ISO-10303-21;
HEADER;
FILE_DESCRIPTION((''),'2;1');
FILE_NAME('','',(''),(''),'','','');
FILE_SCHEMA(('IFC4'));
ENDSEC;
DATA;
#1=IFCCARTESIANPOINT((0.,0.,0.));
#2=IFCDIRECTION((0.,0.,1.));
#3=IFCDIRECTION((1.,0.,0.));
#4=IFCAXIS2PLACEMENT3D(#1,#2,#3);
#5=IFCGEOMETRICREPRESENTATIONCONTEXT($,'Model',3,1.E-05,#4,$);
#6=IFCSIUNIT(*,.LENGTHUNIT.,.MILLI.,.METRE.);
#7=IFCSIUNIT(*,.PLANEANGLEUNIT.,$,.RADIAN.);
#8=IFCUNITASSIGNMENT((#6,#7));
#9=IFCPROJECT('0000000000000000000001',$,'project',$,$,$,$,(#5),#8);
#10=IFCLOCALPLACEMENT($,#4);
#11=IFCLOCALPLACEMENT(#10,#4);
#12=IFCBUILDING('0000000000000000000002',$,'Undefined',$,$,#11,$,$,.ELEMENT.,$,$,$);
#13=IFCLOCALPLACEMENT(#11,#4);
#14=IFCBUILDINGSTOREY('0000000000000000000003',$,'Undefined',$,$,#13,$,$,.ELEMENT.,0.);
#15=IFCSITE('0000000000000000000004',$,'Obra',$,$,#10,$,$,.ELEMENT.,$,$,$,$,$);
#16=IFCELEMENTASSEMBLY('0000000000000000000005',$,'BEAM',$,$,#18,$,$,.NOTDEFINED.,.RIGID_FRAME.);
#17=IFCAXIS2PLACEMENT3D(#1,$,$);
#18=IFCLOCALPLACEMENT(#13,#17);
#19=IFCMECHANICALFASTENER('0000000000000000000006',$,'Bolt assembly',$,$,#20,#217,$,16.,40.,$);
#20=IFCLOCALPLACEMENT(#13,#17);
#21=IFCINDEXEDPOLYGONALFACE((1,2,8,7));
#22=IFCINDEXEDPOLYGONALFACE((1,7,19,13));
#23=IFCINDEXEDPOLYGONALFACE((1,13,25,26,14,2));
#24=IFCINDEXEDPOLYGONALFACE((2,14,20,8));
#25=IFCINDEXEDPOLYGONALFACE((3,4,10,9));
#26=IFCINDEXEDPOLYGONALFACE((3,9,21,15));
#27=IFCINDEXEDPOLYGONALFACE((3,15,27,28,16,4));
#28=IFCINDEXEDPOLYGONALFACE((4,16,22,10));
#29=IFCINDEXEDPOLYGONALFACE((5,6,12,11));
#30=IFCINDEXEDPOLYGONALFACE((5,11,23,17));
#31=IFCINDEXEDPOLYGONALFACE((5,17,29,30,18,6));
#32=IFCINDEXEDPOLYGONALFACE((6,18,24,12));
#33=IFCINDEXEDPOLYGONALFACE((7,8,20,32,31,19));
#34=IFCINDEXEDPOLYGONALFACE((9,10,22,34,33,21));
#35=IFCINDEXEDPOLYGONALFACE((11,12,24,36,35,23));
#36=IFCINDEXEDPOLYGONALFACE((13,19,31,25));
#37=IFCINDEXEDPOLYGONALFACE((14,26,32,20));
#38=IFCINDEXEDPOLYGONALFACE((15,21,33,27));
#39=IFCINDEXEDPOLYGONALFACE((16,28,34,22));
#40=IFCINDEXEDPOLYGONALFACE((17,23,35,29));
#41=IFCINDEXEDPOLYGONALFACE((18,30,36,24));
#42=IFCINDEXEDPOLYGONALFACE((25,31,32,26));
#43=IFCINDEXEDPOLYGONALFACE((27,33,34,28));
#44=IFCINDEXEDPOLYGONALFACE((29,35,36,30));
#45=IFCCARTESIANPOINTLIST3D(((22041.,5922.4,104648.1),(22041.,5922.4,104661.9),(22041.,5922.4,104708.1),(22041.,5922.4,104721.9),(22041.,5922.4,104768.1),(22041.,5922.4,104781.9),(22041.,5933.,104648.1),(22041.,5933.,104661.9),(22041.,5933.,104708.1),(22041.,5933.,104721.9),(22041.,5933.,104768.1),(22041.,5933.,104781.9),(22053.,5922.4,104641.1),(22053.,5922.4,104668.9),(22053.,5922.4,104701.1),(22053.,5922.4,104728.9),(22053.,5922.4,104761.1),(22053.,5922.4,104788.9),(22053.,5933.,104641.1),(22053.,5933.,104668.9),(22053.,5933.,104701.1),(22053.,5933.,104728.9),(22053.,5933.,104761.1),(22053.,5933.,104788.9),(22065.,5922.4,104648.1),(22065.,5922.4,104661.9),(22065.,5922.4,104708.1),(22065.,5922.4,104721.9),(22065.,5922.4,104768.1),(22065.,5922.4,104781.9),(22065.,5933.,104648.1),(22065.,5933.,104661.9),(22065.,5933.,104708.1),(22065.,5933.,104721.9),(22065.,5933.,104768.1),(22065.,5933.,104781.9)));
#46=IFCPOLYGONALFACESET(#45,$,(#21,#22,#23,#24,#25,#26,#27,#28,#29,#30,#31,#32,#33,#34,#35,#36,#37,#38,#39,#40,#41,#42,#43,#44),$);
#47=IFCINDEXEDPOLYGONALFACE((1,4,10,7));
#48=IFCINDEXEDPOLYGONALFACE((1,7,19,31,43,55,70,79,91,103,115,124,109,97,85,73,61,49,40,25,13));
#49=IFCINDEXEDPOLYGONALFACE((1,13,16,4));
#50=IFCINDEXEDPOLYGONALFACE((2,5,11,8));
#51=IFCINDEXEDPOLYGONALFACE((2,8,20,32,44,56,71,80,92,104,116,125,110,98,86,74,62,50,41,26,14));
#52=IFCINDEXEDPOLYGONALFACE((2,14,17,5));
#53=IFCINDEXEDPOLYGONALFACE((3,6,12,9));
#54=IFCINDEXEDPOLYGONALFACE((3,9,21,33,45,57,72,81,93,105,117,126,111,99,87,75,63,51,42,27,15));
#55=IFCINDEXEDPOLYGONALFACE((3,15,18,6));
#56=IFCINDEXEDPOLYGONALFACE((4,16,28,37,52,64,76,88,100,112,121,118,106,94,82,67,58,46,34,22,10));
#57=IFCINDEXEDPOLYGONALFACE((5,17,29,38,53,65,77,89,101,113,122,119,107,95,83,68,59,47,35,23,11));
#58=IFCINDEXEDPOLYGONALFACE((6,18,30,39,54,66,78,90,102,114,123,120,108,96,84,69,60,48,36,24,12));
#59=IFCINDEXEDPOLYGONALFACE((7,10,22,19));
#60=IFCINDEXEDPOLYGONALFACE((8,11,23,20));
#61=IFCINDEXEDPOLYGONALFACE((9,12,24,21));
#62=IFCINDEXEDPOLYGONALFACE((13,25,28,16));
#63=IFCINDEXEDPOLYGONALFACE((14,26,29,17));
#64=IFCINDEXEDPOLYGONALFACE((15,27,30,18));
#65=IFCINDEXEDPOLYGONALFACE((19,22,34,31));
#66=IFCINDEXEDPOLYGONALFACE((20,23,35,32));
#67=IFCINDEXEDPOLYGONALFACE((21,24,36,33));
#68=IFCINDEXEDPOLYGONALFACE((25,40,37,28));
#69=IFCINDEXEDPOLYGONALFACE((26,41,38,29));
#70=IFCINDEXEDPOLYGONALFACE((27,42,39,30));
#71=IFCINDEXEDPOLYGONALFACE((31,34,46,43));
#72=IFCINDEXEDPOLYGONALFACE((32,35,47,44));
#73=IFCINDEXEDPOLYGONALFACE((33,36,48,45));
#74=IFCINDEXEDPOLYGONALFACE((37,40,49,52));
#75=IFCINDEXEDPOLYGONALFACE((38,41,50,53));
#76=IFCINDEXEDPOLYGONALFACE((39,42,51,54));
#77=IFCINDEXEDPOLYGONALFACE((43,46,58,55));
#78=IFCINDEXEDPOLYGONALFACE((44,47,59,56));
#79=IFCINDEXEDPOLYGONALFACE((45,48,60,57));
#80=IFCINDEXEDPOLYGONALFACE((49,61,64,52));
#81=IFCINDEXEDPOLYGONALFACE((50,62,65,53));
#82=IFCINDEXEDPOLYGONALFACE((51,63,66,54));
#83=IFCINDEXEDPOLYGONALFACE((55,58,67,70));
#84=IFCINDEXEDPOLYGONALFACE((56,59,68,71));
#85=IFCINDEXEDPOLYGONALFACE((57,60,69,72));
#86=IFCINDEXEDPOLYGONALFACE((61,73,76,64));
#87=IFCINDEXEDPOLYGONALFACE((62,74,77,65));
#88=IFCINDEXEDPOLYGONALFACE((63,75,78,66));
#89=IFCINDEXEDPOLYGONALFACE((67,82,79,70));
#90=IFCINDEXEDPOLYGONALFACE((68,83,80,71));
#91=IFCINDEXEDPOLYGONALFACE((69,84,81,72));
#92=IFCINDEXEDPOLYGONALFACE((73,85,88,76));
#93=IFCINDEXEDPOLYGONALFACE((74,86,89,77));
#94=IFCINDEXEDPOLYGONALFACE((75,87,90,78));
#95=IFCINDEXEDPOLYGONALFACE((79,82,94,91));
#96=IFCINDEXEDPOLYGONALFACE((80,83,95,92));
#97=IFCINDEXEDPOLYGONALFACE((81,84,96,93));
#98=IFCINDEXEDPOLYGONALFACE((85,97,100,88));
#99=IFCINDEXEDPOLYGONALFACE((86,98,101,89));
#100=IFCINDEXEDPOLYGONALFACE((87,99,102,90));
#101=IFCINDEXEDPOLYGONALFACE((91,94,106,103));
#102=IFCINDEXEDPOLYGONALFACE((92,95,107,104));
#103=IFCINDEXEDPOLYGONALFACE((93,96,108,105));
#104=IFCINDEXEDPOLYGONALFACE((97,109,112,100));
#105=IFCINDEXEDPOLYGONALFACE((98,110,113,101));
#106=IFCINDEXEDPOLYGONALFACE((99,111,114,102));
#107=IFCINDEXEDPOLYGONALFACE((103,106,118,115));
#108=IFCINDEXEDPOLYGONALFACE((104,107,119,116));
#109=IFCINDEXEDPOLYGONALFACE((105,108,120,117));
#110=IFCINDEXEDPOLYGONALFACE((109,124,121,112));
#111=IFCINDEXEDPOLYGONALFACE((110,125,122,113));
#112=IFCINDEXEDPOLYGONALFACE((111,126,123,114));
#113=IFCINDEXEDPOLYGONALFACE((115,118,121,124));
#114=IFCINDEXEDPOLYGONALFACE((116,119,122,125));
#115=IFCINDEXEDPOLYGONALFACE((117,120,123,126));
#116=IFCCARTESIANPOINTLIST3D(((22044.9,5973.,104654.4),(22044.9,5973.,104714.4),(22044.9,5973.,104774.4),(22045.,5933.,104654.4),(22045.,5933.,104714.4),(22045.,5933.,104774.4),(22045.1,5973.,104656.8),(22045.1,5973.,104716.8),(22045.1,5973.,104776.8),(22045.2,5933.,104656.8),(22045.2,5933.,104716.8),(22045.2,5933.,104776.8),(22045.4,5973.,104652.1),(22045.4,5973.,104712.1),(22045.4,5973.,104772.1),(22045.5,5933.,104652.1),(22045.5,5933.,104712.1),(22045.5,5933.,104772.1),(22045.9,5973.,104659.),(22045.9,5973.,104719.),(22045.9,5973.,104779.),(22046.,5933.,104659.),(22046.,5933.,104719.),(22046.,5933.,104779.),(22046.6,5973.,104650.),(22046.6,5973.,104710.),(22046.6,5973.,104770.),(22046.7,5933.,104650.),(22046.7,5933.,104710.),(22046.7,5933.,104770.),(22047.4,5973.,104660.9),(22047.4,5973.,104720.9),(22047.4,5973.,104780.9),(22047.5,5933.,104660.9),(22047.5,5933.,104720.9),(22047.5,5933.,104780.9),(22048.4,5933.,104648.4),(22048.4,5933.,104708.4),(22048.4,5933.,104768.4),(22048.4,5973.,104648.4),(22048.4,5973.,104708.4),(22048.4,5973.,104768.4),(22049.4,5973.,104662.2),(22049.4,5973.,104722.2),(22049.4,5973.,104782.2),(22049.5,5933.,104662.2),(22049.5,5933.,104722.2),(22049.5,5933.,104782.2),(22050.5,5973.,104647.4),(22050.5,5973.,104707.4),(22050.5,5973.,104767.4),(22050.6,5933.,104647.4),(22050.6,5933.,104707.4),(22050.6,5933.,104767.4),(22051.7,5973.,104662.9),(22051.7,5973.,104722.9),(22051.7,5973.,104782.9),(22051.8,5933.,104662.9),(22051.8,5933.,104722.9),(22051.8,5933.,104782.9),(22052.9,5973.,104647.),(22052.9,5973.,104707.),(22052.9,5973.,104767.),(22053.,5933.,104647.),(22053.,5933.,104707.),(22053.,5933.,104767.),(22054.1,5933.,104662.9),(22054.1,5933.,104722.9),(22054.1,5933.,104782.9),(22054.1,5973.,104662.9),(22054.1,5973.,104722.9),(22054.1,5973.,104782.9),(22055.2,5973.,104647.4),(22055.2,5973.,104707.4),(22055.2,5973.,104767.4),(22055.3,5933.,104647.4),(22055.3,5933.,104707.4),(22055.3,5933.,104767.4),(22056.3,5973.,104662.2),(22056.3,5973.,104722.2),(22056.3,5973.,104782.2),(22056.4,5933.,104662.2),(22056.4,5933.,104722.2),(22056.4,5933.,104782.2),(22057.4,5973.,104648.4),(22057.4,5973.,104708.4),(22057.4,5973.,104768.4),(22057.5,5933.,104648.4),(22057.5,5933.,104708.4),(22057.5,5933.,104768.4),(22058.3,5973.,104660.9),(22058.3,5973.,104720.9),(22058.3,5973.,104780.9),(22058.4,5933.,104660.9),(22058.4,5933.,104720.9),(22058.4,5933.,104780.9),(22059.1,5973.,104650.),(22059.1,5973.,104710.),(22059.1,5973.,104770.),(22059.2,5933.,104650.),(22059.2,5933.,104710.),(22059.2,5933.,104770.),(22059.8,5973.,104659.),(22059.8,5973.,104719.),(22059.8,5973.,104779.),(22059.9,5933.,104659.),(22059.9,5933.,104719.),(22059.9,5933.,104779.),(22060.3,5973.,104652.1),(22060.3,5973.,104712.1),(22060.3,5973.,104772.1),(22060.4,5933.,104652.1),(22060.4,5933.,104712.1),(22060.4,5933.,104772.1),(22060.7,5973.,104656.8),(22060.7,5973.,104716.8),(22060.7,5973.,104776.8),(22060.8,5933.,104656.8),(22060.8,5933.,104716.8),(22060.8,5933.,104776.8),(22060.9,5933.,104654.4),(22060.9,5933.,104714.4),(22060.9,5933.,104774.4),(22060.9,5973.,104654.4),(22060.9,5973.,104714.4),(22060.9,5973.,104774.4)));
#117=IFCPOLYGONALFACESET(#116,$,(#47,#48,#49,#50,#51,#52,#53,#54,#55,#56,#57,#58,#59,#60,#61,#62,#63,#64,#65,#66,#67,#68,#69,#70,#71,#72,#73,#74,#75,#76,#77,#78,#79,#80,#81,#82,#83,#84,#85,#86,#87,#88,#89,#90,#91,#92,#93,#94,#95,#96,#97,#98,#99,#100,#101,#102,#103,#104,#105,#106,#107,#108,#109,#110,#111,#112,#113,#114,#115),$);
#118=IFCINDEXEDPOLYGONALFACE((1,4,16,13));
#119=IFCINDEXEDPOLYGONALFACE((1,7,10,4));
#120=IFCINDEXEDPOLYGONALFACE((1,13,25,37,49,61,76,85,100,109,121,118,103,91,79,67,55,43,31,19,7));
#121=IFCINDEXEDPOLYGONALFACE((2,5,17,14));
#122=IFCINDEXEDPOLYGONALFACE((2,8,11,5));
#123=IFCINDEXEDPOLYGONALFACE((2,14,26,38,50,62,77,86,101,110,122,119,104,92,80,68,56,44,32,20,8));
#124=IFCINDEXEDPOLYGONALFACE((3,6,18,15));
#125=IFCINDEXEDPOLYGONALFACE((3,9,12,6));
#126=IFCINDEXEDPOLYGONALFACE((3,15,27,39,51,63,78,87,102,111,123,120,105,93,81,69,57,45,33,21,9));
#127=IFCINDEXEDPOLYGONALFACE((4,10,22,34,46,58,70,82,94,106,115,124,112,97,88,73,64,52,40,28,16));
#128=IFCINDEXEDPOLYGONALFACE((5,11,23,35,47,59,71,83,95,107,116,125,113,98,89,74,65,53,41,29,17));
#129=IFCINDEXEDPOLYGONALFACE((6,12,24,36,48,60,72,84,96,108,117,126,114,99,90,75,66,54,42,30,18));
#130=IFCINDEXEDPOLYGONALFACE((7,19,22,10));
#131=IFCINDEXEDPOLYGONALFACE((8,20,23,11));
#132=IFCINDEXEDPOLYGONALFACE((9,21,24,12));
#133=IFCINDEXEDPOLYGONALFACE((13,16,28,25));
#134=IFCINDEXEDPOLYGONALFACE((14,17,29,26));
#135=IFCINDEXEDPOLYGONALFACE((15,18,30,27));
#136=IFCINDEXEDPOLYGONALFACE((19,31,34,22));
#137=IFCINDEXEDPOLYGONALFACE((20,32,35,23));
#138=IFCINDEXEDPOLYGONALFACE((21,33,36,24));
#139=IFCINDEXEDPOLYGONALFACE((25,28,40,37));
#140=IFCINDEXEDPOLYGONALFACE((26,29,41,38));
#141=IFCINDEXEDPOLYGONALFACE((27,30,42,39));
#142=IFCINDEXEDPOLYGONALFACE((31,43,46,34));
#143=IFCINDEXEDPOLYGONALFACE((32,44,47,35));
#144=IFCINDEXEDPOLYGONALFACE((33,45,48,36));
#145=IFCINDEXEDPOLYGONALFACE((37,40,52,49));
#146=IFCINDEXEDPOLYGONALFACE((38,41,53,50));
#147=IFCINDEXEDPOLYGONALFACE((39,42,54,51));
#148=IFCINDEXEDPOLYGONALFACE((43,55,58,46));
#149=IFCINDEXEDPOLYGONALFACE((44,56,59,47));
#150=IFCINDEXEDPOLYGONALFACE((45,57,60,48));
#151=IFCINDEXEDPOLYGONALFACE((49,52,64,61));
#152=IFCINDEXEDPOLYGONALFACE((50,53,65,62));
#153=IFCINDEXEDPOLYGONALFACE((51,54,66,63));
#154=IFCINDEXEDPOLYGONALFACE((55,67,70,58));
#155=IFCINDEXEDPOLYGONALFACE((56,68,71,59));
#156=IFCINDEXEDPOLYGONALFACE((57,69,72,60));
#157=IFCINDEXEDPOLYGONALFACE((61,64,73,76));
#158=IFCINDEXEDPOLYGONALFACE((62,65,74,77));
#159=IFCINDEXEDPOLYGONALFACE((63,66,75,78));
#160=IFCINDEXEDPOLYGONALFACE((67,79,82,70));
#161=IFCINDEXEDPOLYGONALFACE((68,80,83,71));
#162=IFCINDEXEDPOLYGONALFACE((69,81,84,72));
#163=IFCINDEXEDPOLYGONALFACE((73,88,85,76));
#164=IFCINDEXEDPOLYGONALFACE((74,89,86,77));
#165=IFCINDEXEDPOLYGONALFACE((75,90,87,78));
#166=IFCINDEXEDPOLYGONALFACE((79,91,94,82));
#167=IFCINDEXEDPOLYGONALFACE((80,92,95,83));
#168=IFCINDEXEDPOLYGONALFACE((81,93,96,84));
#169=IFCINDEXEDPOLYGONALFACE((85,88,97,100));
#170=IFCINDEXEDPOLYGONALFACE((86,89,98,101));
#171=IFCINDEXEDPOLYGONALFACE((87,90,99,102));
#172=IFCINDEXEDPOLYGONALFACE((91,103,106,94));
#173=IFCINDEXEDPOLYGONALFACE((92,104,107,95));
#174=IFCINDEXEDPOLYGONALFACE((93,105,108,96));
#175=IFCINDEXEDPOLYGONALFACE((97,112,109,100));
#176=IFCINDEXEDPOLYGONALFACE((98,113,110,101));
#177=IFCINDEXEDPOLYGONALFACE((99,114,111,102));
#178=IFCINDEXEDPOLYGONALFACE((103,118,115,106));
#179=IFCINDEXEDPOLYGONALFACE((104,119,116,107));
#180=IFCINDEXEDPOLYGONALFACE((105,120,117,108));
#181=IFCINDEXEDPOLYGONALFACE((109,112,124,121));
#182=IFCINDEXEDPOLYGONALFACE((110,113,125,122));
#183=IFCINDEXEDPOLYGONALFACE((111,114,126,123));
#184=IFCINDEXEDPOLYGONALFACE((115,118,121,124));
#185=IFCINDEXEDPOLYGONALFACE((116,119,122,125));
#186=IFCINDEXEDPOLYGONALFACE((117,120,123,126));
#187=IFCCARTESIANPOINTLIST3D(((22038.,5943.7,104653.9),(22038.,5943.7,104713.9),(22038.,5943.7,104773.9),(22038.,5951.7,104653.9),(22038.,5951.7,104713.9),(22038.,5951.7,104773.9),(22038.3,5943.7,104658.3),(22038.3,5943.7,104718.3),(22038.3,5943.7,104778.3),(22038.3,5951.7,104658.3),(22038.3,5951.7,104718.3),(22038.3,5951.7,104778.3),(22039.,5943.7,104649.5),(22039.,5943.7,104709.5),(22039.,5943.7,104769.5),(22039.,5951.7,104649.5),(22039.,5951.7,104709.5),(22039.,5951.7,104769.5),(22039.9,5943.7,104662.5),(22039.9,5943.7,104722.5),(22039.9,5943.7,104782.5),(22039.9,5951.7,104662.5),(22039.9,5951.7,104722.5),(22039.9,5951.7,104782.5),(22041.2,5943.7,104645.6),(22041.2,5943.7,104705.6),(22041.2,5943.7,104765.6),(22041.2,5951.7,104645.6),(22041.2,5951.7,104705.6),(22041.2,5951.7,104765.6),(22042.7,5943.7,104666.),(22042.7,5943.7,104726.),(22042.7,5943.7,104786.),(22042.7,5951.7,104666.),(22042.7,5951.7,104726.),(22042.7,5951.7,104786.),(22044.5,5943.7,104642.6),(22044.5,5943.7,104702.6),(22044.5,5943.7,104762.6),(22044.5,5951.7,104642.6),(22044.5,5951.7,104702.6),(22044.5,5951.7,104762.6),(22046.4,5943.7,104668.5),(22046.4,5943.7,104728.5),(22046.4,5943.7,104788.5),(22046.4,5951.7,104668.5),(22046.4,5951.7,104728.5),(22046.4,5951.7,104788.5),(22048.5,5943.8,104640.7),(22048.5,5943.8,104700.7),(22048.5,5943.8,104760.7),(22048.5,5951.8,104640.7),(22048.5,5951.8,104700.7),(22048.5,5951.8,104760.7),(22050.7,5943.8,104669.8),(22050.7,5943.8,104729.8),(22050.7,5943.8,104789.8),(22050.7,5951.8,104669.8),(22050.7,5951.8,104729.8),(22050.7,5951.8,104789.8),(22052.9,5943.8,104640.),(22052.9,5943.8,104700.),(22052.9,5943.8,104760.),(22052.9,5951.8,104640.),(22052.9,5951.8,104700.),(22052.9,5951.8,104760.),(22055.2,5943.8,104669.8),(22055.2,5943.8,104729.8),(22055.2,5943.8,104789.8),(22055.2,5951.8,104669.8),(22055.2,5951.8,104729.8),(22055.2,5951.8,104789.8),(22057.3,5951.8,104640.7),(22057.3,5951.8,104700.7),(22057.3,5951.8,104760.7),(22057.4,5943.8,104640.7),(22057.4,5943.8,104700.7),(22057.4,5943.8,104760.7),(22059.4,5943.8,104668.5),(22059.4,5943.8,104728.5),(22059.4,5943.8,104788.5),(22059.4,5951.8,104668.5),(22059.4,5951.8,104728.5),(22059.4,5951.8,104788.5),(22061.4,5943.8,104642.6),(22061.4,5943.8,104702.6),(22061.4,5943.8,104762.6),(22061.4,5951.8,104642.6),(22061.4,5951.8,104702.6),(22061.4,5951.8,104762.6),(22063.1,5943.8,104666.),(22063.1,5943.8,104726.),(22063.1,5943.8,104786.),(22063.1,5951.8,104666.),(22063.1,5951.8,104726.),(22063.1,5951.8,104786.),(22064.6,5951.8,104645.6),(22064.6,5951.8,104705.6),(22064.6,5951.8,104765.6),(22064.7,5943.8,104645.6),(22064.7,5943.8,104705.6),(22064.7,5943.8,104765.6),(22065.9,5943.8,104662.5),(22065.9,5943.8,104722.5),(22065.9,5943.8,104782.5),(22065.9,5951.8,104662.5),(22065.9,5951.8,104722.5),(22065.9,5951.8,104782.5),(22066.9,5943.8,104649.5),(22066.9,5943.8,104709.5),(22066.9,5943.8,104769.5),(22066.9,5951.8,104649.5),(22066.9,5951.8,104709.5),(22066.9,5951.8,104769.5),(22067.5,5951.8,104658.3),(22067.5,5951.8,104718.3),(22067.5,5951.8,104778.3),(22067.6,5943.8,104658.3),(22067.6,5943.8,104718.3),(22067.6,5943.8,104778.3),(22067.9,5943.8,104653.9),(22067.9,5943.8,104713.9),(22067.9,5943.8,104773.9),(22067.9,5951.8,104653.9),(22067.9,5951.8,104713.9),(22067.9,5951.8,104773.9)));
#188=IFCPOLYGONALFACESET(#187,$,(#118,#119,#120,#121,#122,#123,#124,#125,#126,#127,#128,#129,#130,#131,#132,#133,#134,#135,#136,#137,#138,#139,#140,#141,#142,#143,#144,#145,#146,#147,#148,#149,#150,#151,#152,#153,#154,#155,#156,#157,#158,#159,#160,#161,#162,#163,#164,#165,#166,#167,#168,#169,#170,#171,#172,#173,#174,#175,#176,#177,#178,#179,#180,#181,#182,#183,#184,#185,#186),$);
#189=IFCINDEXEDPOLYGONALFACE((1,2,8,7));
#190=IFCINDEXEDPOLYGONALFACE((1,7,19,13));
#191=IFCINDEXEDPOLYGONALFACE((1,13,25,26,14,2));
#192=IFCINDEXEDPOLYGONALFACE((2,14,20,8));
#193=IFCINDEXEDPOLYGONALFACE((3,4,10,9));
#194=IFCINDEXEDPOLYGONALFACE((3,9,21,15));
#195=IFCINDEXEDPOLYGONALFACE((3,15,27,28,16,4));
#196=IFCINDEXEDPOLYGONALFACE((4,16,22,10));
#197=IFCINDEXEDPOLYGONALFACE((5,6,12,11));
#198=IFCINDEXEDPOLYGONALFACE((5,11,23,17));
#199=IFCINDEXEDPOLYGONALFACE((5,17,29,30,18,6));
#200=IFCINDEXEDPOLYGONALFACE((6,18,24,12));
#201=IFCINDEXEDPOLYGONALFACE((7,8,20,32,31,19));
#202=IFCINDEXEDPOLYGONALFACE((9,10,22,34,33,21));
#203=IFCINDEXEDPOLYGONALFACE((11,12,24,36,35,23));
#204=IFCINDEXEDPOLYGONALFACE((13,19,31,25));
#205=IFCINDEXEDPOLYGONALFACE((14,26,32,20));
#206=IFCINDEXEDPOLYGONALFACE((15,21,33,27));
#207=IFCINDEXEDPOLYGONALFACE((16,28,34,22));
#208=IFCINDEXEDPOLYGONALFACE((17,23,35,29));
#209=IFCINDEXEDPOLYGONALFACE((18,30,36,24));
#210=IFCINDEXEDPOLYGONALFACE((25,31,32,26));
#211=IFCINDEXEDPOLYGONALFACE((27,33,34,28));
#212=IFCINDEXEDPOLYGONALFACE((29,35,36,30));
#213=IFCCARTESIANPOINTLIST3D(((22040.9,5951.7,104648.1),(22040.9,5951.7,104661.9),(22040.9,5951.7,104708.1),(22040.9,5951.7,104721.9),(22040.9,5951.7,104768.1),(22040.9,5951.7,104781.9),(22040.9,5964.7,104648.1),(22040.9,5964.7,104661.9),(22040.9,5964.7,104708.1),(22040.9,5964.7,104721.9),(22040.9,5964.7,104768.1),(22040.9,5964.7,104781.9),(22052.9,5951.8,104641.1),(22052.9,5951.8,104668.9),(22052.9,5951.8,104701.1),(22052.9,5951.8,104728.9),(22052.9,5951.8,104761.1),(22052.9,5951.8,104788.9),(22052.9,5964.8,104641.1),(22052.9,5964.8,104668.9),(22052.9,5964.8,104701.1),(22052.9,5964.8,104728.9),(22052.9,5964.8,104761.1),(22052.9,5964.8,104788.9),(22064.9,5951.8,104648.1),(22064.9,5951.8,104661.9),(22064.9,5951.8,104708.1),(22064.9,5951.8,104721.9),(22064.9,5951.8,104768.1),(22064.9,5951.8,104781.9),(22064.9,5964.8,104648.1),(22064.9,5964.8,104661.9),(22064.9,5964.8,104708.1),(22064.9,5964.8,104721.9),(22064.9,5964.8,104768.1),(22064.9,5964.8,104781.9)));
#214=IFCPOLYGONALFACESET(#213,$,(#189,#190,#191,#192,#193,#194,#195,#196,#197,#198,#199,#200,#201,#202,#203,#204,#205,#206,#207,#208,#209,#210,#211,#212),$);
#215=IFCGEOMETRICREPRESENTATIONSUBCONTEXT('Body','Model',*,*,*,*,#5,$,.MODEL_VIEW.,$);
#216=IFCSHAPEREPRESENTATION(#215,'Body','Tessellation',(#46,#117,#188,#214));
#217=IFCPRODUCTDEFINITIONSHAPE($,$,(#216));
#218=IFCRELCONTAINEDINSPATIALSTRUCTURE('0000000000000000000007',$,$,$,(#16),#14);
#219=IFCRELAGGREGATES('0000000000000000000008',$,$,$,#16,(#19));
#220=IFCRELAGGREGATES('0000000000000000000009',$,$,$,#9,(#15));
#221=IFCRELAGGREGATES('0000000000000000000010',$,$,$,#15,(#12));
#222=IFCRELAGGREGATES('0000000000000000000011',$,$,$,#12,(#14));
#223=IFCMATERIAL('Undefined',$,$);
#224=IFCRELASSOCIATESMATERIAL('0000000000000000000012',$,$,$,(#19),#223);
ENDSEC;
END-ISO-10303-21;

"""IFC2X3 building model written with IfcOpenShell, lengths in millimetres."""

from ifc_helpers import new_model, si_unit, frame, origin_with_axes, origin_2d_with_axis, place, context, subcontext, project, spatial, polyline, circle, outline, extrude, source, transform, mapped, material, element, aggregate, save


model = new_model("IFC2X3")

# Units and contexts
model_context = context("Model", 3, precision=1e-05, world=origin_with_axes())
body_context = subcontext(model_context, "Body", "Model", "MODEL_VIEW")
ifc_project = project(units=[si_unit("LENGTHUNIT", "METRE", prefix="MILLI"), si_unit("PLANEANGLEUNIT", "RADIAN")], contexts=[model_context])

# Site, building, storey
site_placement = place(None, origin_with_axes())
site = spatial("IfcSite", under=ifc_project, at=site_placement, Name="Obra", CompositionType="ELEMENT")
building_placement = place(site_placement, origin_with_axes())
building = spatial("IfcBuilding", under=site, at=building_placement, Name="Undefined", CompositionType="ELEMENT")
storey_placement = place(building_placement, origin_with_axes())
storey = spatial("IfcBuildingStorey", under=building, at=storey_placement, Name="Undefined", CompositionType="ELEMENT", Elevation=0.0)

# Element assembly
assembly_1_placement = place(storey_placement, origin_with_axes())
assembly_1 = element("IfcElementAssembly", 1, at=assembly_1_placement, inside=storey, Name="BEAM", AssemblyPlace="NOTDEFINED", PredefinedType="RIGID_FRAME")
ifc_material_1 = material(Name="Undefined")

# Mechanical fastener
shared_shape_1 = source(origin_with_axes(), body_context, "Body", "SweptSolid", [
    extrude(outline(polyline([(13.9, 0.0), (6.9, 12.0), (-6.9, 12.0), (-13.9, 0.0), (-6.9, -12.0), (6.9, -12.0), (13.9, 0.0)])), frame((0.0, -18.0, 0.0), z_axis=(0.0, 1.0, 0.0), x_axis=(1.0, 0.0, 0.0)), (0.0, 0.0, 1.0), 10.6),
    extrude(circle(Radius=8.0, at=origin_2d_with_axis()), frame((0.0, -7.5, 0.0), z_axis=(0.0, 1.0, 0.0), x_axis=(1.0, 0.0, 0.0)), (0.0, 0.0, 1.0), 40.0),
    extrude(circle(Radius=15.0, at=origin_2d_with_axis()), frame((0.0, 3.3, 0.0), z_axis=(0.0, 1.0, 0.0), x_axis=(1.0, 0.0, 0.0)), (0.0, 0.0, 1.0), 8.0),
    extrude(outline(polyline([(13.9, 0.0), (6.9, 12.0), (-6.9, 12.0), (-13.9, 0.0), (-6.9, -12.0), (6.9, -12.0), (13.9, 0.0)])), frame((0.0, 11.3, 0.0), z_axis=(0.0, 1.0, 0.0), x_axis=(1.0, 0.0, 0.0)), (0.0, 0.0, 1.0), 13.0),
])
mechanical_fastener_1_placement = place(assembly_1_placement, frame((22017.9, 5940.4, 104850.0), z_axis=(0.999998, 0.00197, 0.0), x_axis=(0.0, 0.0, -1.0)))
mechanical_fastener_1 = element("IfcMechanicalFastener", 2, at=mechanical_fastener_1_placement, material=ifc_material_1, Name="Bolt assembly", NominalDiameter=16.0, NominalLength=40.0, context=body_context, shape_type="MappedRepresentation", body=[
    mapped(shared_shape_1, transform((75.0, 0.0, 35.0))),
    mapped(shared_shape_1, transform((135.0, 0.0, 35.0))),
    mapped(shared_shape_1, transform((195.0, 0.0, 35.0))),
])
aggregate(assembly_1, [mechanical_fastener_1])

save(model, "model.ifc")
